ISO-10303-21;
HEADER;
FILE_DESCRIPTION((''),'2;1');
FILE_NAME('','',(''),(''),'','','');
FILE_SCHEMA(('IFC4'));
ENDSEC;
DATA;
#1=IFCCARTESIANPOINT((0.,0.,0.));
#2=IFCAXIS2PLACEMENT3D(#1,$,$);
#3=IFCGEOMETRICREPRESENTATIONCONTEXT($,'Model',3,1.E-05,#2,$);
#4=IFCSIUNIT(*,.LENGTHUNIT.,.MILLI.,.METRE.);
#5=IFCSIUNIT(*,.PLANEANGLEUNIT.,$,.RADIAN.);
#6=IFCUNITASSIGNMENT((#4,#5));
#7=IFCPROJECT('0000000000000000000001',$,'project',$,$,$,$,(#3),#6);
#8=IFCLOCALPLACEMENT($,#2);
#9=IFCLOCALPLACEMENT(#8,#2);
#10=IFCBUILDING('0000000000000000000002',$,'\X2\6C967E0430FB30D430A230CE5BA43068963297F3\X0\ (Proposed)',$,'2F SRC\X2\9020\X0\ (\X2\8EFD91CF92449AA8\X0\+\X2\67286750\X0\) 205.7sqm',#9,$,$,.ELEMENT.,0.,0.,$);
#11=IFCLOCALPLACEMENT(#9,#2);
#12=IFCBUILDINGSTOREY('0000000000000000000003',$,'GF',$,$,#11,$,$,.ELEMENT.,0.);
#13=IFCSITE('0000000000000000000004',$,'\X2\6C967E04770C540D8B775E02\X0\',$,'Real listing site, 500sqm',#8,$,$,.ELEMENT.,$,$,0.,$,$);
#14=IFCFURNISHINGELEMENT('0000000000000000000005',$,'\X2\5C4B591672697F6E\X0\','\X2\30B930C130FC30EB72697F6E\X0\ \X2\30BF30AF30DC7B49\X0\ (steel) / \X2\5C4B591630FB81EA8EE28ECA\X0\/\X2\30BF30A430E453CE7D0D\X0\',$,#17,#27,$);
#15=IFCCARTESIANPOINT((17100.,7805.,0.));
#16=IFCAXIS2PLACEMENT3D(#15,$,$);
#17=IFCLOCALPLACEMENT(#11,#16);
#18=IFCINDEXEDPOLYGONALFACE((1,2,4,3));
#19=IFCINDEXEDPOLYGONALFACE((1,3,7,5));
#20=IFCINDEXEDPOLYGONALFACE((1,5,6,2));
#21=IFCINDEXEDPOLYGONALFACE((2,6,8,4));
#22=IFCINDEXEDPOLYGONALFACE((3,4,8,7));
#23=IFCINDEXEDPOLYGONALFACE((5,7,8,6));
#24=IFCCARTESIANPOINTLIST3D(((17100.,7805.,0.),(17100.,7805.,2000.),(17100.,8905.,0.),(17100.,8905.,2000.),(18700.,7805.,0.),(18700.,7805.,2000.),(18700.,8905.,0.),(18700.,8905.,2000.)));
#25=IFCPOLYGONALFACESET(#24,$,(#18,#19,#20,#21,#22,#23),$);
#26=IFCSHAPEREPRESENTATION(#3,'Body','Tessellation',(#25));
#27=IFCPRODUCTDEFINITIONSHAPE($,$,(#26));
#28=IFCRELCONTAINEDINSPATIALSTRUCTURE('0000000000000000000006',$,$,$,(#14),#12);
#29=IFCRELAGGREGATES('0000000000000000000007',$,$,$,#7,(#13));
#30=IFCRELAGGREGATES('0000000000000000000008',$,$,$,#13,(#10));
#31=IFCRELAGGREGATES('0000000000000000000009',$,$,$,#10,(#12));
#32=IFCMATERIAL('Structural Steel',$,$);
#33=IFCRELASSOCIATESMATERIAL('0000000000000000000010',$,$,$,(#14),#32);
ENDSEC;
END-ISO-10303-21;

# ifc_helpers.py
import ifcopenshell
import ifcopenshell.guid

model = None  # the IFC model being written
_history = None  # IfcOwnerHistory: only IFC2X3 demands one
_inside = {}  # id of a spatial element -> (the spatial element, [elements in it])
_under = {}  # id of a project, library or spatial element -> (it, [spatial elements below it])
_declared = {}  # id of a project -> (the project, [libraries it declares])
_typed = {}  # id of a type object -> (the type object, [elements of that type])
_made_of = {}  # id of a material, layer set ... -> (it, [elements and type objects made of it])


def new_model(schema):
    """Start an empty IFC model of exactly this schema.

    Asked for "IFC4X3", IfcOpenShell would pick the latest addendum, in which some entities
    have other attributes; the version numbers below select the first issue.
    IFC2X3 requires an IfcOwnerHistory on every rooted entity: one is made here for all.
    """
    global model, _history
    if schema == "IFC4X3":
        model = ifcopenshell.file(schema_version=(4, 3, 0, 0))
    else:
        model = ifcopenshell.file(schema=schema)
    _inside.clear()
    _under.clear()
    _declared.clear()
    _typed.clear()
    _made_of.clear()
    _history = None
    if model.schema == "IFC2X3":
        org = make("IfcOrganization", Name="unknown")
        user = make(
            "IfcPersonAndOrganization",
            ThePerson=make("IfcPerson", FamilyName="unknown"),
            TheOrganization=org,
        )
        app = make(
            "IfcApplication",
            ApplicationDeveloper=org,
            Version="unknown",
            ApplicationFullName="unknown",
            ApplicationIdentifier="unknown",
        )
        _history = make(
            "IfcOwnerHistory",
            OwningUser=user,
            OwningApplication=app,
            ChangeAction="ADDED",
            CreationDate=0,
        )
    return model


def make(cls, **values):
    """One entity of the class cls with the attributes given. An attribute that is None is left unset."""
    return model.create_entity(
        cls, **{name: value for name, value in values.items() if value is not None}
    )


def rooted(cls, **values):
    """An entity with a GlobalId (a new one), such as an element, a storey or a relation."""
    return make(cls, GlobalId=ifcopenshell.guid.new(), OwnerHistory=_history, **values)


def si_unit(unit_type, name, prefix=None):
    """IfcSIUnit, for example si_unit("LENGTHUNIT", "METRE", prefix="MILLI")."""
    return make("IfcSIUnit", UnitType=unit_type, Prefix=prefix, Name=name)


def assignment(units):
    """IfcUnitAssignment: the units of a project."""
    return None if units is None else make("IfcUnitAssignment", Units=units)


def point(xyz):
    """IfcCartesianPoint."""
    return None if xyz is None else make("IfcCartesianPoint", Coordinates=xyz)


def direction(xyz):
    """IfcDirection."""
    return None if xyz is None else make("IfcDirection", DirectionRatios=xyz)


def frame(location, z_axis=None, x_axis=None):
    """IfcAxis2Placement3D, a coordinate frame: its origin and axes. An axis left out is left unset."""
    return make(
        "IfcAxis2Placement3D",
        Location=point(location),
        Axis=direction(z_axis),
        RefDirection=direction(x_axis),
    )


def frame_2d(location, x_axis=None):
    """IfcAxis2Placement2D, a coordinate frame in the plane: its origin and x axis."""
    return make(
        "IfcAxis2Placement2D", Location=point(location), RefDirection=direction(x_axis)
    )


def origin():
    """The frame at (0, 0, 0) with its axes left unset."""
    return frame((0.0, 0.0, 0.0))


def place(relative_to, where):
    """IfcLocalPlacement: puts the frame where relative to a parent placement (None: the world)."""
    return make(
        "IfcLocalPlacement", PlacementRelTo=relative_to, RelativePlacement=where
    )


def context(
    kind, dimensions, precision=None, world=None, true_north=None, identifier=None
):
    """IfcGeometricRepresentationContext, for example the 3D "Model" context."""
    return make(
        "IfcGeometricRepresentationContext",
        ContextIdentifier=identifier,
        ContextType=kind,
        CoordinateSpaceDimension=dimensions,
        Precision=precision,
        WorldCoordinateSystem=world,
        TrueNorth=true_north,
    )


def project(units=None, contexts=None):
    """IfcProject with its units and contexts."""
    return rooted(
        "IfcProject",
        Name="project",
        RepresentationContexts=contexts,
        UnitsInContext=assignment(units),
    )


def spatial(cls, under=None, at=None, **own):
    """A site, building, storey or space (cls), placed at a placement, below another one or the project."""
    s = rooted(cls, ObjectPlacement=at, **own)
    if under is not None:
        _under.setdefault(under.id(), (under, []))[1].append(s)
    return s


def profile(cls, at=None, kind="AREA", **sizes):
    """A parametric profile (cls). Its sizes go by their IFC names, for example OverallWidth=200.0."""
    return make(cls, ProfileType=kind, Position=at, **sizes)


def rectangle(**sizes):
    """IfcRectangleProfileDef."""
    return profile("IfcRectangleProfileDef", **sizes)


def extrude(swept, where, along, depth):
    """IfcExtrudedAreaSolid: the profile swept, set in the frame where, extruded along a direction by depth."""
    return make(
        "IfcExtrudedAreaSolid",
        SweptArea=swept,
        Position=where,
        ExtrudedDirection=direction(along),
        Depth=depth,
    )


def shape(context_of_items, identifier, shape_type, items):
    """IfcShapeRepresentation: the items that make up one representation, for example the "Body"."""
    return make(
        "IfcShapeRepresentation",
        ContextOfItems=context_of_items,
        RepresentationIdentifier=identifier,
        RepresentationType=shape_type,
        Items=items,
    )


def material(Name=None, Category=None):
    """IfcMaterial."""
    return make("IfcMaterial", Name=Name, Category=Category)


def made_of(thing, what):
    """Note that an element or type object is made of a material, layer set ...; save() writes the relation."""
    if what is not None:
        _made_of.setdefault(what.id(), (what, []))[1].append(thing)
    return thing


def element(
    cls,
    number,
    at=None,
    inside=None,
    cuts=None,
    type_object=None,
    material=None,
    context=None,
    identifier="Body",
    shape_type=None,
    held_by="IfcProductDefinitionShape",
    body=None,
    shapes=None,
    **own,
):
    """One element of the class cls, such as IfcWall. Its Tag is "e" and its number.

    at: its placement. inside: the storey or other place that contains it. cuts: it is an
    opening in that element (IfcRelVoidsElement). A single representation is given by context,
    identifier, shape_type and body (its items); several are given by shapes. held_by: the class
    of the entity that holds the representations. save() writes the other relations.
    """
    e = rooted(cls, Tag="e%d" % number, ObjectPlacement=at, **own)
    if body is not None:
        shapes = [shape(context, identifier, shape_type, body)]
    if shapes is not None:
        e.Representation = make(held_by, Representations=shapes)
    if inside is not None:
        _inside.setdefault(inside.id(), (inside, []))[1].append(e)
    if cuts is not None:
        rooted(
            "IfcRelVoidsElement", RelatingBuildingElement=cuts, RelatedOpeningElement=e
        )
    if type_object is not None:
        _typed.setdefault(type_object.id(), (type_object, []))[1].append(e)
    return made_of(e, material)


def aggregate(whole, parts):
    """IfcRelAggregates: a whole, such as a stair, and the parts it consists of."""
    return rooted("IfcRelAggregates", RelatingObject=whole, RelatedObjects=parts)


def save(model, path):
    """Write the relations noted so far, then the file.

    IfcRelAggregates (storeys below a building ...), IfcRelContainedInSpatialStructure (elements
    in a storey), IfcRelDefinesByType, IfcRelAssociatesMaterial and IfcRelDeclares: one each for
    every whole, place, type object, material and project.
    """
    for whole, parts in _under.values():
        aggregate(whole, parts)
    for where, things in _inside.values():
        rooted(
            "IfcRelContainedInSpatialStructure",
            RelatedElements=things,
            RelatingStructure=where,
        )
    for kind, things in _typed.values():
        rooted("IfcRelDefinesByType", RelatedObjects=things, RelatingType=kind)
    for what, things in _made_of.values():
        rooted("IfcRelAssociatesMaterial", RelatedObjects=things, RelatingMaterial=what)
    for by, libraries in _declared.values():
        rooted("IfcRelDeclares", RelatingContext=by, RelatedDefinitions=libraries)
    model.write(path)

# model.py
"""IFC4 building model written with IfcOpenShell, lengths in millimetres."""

from ifc_helpers import new_model, si_unit, frame, frame_2d, origin, place, context, project, spatial, rectangle, extrude, material, element, save


model = new_model("IFC4")

# Units and contexts
model_context = context("Model", 3, precision=1e-05, world=origin())
ifc_project = project(units=[si_unit("LENGTHUNIT", "METRE", prefix="MILLI"), si_unit("PLANEANGLEUNIT", "RADIAN")], contexts=[model_context])

# Site, building, storey
site_placement = place(None, origin())
site = spatial("IfcSite", under=ifc_project, at=site_placement, Name="沖縄県名護市", ObjectType="Real listing site, 500sqm", CompositionType="ELEMENT", RefElevation=0.0)
building_placement = place(site_placement, origin())
building = spatial("IfcBuilding", under=site, at=building_placement, Name="沖縄・ピアノ室と防音 (Proposed)", ObjectType="2F SRC造 (軽量鉄骨+木材) 205.7sqm", CompositionType="ELEMENT", ElevationOfRefHeight=0.0, ElevationOfTerrain=0.0)
storey_placement = place(building_placement, origin())
storey = spatial("IfcBuildingStorey", under=building, at=storey_placement, Name="GF", CompositionType="ELEMENT", Elevation=0.0)

# Shared definitions
ifc_material_1 = material(Name="Structural Steel")

# Furnishing element
furnishing_1_placement = place(storey_placement, frame((17100.0, 7805.0, 0.0)))
element("IfcFurnishingElement", 1, at=furnishing_1_placement, inside=storey, material=ifc_material_1, Name="屋外物置", Description="スチール物置 タクボ等 (steel) / 屋外・自転車/タイヤ収納", context=model_context, shape_type="SweptSolid", body=[
    extrude(rectangle(XDim=1600.0, YDim=1100.0, at=frame_2d((800.0, 550.0))), frame((17100.0, 7805.0, 0.0)), (0.0, 0.0, 1.0), 2000.0),
])

save(model, "model.ifc")
